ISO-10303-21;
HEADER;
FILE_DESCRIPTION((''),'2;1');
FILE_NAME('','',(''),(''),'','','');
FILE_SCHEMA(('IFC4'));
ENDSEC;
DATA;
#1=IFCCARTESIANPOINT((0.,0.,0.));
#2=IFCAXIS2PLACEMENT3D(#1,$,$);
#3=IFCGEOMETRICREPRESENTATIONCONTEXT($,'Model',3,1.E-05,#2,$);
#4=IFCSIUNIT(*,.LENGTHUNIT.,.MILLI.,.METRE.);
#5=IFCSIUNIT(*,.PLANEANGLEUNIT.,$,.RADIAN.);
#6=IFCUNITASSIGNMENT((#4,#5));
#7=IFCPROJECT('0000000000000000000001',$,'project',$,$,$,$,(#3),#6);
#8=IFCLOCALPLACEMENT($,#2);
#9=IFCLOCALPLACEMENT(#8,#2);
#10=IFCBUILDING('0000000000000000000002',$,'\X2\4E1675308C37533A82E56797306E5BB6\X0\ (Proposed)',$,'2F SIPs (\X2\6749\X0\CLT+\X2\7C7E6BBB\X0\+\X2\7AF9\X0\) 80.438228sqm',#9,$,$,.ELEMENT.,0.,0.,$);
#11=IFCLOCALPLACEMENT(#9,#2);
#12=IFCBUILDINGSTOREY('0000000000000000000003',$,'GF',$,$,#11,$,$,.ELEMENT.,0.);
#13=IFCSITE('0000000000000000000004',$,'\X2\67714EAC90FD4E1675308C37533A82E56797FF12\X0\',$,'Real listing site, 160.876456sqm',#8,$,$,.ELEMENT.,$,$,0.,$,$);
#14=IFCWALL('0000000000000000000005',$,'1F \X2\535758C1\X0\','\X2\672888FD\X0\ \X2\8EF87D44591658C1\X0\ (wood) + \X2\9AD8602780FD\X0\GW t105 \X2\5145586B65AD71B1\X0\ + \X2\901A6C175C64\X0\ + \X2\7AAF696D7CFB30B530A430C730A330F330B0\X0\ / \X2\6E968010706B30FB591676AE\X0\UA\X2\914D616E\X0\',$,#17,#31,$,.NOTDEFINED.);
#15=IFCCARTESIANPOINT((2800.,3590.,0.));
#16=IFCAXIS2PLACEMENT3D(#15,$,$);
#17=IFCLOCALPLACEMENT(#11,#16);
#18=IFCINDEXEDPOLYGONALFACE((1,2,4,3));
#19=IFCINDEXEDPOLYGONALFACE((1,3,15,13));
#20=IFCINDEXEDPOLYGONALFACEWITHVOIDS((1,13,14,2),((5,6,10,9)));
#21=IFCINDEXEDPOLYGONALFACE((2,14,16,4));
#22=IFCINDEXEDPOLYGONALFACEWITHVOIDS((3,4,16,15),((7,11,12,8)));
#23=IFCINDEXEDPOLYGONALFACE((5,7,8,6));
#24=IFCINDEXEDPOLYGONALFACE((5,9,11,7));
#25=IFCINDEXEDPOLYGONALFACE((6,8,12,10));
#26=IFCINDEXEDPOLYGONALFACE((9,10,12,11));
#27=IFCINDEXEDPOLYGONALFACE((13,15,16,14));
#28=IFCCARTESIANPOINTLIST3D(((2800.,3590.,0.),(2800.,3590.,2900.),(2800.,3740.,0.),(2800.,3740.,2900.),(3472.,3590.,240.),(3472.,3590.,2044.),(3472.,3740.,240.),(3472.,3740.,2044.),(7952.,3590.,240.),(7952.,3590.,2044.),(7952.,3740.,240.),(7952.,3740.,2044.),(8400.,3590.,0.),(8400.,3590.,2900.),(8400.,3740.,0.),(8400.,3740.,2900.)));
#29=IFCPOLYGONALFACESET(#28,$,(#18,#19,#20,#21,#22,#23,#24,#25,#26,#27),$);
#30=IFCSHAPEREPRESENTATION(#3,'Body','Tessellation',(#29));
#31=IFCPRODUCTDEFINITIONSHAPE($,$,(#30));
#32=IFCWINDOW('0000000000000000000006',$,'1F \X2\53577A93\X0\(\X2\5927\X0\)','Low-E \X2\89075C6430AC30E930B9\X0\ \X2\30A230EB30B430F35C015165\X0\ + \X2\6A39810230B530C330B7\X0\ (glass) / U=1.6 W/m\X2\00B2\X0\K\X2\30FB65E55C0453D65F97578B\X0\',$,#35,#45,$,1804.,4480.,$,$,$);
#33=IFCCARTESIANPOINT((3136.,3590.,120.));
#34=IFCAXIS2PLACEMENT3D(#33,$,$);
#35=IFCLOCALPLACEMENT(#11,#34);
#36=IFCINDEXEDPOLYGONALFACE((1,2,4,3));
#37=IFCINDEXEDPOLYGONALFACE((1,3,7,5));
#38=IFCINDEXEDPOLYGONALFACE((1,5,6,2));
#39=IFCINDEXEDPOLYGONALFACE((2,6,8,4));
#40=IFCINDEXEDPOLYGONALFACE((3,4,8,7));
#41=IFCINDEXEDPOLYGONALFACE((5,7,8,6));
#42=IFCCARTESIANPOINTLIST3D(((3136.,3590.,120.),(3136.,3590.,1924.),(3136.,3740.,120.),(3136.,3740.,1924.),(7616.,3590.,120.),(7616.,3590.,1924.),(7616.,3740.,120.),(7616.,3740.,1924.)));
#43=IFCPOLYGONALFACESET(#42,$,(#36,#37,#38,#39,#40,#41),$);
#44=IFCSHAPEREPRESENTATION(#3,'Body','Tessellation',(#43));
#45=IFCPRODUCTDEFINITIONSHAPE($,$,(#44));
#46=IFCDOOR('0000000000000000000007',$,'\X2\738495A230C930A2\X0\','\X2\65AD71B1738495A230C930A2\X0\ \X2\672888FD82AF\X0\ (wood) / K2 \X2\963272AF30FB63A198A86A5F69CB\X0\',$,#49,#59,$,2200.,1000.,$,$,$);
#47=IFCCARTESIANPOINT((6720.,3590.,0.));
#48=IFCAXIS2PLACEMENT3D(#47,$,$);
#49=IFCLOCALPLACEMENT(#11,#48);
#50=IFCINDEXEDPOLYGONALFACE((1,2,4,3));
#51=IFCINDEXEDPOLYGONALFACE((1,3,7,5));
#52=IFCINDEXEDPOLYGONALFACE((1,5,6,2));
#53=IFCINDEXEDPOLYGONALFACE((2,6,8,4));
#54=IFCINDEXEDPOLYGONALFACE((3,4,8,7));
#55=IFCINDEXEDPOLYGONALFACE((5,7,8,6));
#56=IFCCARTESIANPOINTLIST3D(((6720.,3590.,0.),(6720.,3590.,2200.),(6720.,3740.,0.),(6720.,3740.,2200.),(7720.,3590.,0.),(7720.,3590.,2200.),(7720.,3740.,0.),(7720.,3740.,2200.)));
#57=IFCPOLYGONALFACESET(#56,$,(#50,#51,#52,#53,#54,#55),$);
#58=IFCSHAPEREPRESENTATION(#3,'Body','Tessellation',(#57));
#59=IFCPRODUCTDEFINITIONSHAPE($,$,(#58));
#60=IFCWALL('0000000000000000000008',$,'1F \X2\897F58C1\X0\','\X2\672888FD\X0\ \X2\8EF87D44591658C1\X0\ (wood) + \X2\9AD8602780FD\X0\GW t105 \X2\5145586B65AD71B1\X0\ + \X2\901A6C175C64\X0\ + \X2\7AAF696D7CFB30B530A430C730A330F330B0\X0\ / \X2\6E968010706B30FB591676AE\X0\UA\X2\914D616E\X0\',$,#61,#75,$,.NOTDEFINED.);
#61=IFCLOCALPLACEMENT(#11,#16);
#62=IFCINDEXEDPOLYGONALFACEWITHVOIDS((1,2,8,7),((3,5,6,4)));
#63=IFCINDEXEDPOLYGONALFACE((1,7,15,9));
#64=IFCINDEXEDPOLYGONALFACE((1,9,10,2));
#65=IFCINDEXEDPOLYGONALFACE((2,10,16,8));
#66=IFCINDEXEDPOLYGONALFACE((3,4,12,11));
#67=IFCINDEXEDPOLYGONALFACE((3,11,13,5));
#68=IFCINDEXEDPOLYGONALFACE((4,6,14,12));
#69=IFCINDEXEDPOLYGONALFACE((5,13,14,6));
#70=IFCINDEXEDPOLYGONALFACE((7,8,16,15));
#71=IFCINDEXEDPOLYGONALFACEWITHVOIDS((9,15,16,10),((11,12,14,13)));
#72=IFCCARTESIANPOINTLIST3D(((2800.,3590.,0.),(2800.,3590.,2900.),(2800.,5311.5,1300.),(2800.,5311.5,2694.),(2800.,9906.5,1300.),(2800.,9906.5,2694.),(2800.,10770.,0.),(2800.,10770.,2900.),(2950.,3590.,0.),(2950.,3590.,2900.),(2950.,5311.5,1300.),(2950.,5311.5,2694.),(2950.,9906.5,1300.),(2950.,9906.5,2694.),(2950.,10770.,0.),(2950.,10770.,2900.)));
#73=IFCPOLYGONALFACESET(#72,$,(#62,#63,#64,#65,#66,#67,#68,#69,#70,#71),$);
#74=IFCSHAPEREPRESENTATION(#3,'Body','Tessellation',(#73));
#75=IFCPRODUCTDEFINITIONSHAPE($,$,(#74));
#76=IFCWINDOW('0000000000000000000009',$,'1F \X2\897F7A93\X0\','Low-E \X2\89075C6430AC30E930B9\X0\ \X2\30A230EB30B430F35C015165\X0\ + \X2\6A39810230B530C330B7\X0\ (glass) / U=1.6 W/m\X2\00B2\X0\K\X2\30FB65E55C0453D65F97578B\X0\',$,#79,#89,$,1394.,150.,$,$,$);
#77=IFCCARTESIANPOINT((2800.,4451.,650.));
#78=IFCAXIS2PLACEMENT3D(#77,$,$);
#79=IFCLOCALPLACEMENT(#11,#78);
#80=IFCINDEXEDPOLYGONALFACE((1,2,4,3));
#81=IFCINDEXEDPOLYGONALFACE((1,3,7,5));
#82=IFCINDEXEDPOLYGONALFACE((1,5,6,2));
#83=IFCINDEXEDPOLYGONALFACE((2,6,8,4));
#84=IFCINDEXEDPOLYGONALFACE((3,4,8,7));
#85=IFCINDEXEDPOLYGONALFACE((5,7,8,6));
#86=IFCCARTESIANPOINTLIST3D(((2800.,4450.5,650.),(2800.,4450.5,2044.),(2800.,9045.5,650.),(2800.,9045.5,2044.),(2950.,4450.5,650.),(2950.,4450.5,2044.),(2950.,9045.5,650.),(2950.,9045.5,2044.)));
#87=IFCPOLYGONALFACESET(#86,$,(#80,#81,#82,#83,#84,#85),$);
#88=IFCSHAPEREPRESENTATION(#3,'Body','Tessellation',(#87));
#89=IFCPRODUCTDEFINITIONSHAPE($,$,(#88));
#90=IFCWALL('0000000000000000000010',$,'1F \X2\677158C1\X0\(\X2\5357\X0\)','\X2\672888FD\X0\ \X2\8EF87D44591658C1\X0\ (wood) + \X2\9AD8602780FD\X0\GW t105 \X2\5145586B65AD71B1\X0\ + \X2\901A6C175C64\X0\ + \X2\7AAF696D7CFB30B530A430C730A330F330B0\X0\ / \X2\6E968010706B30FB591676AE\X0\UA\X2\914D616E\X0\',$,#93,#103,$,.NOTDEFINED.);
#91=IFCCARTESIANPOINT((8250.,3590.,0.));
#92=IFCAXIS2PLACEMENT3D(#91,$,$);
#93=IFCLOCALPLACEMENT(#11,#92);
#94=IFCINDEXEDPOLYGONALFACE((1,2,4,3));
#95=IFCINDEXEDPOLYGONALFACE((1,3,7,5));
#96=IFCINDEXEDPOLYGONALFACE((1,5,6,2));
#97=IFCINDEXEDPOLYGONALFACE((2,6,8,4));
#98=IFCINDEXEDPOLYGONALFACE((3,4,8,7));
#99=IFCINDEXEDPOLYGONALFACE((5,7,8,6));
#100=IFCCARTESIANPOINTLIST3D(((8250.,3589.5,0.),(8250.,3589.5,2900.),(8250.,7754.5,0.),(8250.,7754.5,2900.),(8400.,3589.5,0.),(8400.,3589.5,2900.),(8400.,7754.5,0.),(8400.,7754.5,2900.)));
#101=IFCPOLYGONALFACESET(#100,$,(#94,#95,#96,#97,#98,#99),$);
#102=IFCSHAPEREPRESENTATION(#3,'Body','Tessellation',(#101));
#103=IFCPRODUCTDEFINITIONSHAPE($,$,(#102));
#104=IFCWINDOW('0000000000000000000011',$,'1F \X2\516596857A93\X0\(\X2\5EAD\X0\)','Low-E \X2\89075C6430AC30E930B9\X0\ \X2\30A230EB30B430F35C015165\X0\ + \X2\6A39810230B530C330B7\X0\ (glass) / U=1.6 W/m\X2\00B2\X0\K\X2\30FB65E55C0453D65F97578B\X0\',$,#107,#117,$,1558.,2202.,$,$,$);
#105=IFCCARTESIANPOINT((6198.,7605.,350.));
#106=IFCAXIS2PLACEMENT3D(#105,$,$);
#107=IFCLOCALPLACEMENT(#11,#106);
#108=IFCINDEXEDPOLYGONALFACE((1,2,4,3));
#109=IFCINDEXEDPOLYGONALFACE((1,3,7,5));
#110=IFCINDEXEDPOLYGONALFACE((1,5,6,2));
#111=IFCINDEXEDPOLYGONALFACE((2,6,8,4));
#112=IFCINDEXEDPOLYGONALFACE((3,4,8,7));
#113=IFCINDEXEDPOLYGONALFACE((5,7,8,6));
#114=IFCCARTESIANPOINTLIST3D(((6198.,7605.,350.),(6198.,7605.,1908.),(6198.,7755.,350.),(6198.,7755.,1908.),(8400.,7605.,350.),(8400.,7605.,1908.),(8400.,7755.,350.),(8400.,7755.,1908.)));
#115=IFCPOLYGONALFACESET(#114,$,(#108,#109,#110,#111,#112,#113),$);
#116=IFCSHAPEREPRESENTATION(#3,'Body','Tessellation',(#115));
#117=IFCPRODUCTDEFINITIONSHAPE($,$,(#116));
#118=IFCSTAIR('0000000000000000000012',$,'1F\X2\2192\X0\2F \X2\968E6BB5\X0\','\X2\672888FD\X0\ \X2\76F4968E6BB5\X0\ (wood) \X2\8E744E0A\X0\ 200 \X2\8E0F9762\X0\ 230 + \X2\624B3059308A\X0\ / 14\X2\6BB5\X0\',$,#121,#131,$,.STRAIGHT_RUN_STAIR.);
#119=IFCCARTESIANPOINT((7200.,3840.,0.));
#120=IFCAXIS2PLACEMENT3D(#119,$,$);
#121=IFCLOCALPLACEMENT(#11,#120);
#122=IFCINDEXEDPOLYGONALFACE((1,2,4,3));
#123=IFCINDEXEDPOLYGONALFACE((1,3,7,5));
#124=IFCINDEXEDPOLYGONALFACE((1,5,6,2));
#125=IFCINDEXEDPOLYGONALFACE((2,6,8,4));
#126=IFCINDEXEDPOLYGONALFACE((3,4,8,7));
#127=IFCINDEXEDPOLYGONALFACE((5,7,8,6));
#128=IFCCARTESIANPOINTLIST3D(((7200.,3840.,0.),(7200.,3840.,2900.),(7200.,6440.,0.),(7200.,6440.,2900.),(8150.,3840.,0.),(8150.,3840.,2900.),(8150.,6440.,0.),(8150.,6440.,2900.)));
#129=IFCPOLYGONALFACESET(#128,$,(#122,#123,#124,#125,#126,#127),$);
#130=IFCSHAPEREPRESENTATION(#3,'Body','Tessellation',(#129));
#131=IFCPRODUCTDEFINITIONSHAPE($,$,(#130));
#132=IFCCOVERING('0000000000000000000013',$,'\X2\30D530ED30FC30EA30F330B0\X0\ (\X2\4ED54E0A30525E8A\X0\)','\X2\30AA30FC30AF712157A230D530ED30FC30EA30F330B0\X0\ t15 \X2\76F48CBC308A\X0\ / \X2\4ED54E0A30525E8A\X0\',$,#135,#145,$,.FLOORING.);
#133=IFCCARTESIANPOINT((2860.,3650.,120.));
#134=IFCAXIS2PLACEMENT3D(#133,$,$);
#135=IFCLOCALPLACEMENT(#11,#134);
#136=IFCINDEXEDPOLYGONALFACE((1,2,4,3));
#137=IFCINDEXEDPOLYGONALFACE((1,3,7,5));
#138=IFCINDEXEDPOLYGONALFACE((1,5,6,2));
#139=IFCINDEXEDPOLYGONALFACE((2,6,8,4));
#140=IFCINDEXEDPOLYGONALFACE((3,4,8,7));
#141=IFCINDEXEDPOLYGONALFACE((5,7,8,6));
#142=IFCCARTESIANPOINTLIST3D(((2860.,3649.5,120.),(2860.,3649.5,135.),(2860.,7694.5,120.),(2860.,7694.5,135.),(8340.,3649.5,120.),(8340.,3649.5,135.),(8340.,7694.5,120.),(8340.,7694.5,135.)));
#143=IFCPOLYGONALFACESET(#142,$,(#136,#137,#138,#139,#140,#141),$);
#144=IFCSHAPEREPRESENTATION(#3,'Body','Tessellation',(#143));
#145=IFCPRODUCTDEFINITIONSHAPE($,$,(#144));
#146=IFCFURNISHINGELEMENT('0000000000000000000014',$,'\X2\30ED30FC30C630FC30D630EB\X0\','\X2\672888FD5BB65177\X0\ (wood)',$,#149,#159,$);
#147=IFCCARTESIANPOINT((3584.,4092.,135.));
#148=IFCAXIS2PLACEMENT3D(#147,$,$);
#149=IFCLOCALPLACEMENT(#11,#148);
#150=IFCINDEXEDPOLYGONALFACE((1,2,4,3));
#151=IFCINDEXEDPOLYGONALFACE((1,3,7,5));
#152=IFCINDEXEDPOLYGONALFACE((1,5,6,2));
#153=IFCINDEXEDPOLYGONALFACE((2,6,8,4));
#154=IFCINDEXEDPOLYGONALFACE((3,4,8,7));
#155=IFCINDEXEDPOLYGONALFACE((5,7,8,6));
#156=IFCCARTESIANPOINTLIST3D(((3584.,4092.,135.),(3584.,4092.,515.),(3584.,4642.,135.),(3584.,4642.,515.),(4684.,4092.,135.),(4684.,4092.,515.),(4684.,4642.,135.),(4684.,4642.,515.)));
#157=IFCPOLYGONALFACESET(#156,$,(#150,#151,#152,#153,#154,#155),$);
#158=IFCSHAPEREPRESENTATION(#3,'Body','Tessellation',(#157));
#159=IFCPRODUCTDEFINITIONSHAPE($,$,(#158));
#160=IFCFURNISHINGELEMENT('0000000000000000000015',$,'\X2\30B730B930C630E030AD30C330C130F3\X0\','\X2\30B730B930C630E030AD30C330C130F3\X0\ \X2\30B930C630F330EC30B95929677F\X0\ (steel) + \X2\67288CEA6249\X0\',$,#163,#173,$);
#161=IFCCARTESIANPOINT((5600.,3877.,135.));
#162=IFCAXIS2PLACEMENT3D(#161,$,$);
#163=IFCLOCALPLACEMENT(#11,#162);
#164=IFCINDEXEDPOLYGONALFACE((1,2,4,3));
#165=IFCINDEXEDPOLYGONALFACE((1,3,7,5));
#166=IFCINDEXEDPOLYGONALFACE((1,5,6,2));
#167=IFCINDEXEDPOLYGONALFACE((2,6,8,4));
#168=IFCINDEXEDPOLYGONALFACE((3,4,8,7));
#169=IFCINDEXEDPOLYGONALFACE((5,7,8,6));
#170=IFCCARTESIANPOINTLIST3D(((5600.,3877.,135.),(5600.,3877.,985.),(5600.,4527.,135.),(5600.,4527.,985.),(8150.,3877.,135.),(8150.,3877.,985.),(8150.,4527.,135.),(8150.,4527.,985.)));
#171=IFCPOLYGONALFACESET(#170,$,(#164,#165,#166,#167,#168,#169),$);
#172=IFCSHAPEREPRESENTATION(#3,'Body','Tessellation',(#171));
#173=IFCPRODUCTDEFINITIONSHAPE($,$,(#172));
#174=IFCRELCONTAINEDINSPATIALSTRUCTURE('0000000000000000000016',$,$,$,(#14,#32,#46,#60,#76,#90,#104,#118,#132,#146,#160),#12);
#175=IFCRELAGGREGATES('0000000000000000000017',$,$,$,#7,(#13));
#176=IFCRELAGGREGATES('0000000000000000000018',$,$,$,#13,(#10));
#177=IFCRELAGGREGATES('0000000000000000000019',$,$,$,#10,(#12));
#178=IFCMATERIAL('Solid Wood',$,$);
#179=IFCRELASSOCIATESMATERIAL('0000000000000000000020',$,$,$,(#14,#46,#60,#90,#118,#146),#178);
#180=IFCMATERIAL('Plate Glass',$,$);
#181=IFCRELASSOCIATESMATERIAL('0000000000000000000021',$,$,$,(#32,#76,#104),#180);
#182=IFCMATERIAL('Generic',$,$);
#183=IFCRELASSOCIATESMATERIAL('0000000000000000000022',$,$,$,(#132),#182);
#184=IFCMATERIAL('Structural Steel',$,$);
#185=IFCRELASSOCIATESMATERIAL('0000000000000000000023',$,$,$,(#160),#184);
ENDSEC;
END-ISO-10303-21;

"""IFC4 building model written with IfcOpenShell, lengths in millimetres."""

from ifc_helpers import new_model, si_unit, frame, frame_2d, origin, place, context, project, spatial, rectangle, extrude, material, element, fill, save


model = new_model("IFC4")

# Units and contexts
model_context = context("Model", 3, precision=1e-05, world=origin())
ifc_project = project(units=[si_unit("LENGTHUNIT", "METRE", prefix="MILLI"), si_unit("PLANEANGLEUNIT", "RADIAN")], contexts=[model_context])

# Site, building, storey
site_placement = place(None, origin())
site = spatial("IfcSite", under=ifc_project, at=site_placement, Name="東京都世田谷区若林２", ObjectType="Real listing site, 160.876456sqm", CompositionType="ELEMENT", RefElevation=0.0)
building_placement = place(site_placement, origin())
building = spatial("IfcBuilding", under=site, at=building_placement, Name="世田谷区若林の家 (Proposed)", ObjectType="2F SIPs (杉CLT+籾殻+竹) 80.438228sqm", CompositionType="ELEMENT", ElevationOfRefHeight=0.0, ElevationOfTerrain=0.0)
storey_placement = place(building_placement, origin())
storey = spatial("IfcBuildingStorey", under=building, at=storey_placement, Name="GF", CompositionType="ELEMENT", Elevation=0.0)

# Shared definitions
ifc_material_1 = material(Name="Solid Wood")

# Wall, openings, window, door
wall_1_placement = place(storey_placement, frame((2800.0, 3590.0, 0.0)))
wall_1 = element("IfcWall", 1, at=wall_1_placement, inside=storey, material=ifc_material_1, Name="1F 南壁", Description="木製 軸組外壁 (wood) + 高性能GW t105 充填断熱 + 通気層 + 窯業系サイディング / 準耐火・外皮UA配慮", PredefinedType="NOTDEFINED", context=model_context, shape_type="SweptSolid", body=[
    extrude(rectangle(XDim=5600.0, YDim=150.0, at=frame_2d((2800.0, 75.0))), frame((2800.0, 3590.0, 0.0)), (0.0, 0.0, 1.0), 2900.0),
])
opening_1_placement = place(storey_placement, frame((3136.0, 3590.0, 120.0)))
opening_1 = element("IfcOpeningElement", 2, at=opening_1_placement, cuts=wall_1, PredefinedType="NOTDEFINED", context=model_context, shape_type="SweptSolid", body=[
    extrude(rectangle(XDim=4480.0, YDim=150.0, at=frame_2d((2240.0, 75.0))), frame((3136.0, 3590.0, 120.0)), (0.0, 0.0, 1.0), 1804.0),
])
opening_2_placement = place(storey_placement, frame((6720.0, 3590.0, 0.0)))
opening_2 = element("IfcOpeningElement", 3, at=opening_2_placement, cuts=wall_1, PredefinedType="NOTDEFINED", context=model_context, shape_type="SweptSolid", body=[
    extrude(rectangle(XDim=1000.0, YDim=150.0, at=frame_2d((500.0, 75.0))), frame((6720.0, 3590.0, 0.0)), (0.0, 0.0, 1.0), 2200.0),
])
ifc_material_2 = material(Name="Plate Glass")
window_1_placement = place(storey_placement, frame((3136.0, 3590.0, 120.0)))
window_1 = element("IfcWindow", 4, at=window_1_placement, inside=storey, material=ifc_material_2, Name="1F 南窓(大)", Description="Low-E 複層ガラス アルゴン封入 + 樹脂サッシ (glass) / U=1.6 W/m²K・日射取得型", OverallHeight=1804.0, OverallWidth=4480.0, context=model_context, shape_type="SweptSolid", body=[
    extrude(rectangle(XDim=4480.0, YDim=150.0, at=frame_2d((2240.0, 75.0))), frame((3136.0, 3590.0, 120.0)), (0.0, 0.0, 1.0), 1804.0),
])
fill(opening_1, window_1)
door_1_placement = place(storey_placement, frame((6720.0, 3590.0, 0.0)))
door_1 = element("IfcDoor", 5, at=door_1_placement, inside=storey, material=ifc_material_1, Name="玄関ドア", Description="断熱玄関ドア 木製芯 (wood) / K2 防犯・採風機構", OverallHeight=2200.0, OverallWidth=1000.0, context=model_context, shape_type="SweptSolid", body=[
    extrude(rectangle(XDim=1000.0, YDim=150.0, at=frame_2d((500.0, 75.0))), frame((6720.0, 3590.0, 0.0)), (0.0, 0.0, 1.0), 2200.0),
])
fill(opening_2, door_1)

# Walls, openings, windows
wall_2_placement = place(storey_placement, frame((2800.0, 3590.0, 0.0)))
wall_2 = element("IfcWall", 6, at=wall_2_placement, inside=storey, material=ifc_material_1, Name="1F 西壁", Description="木製 軸組外壁 (wood) + 高性能GW t105 充填断熱 + 通気層 + 窯業系サイディング / 準耐火・外皮UA配慮", PredefinedType="NOTDEFINED", context=model_context, shape_type="SweptSolid", body=[
    extrude(rectangle(XDim=150.0, YDim=7180.0, at=frame_2d((75.0, 3590.0))), frame((2800.0, 3590.0, 0.0)), (0.0, 0.0, 1.0), 2900.0),
])
opening_3_placement = place(storey_placement, frame((2800.0, 4451.0, 650.0)))
opening_3 = element("IfcOpeningElement", 7, at=opening_3_placement, cuts=wall_2, PredefinedType="NOTDEFINED", context=model_context, shape_type="SweptSolid", body=[
    extrude(rectangle(XDim=150.0, YDim=4595.0, at=frame_2d((75.0, 2297.0))), frame((2800.0, 4451.0, 650.0)), (0.0, 0.0, 1.0), 1394.0),
])
window_2_placement = place(storey_placement, frame((2800.0, 4451.0, 650.0)))
window_2 = element("IfcWindow", 8, at=window_2_placement, inside=storey, material=ifc_material_2, Name="1F 西窓", Description="Low-E 複層ガラス アルゴン封入 + 樹脂サッシ (glass) / U=1.6 W/m²K・日射取得型", OverallHeight=1394.0, OverallWidth=150.0, context=model_context, shape_type="SweptSolid", body=[
    extrude(rectangle(XDim=150.0, YDim=4595.0, at=frame_2d((75.0, 2297.0))), frame((2800.0, 4451.0, 650.0)), (0.0, 0.0, 1.0), 1394.0),
])
fill(opening_3, window_2)
wall_3_placement = place(storey_placement, frame((8250.0, 3590.0, 0.0)))
wall_3 = element("IfcWall", 9, at=wall_3_placement, inside=storey, material=ifc_material_1, Name="1F 東壁(南)", Description="木製 軸組外壁 (wood) + 高性能GW t105 充填断熱 + 通気層 + 窯業系サイディング / 準耐火・外皮UA配慮", PredefinedType="NOTDEFINED", context=model_context, shape_type="SweptSolid", body=[
    extrude(rectangle(XDim=150.0, YDim=4165.0, at=frame_2d((75.0, 2082.0))), frame((8250.0, 3590.0, 0.0)), (0.0, 0.0, 1.0), 2900.0),
])
opening_4_placement = place(storey_placement, frame((6198.0, 7605.0, 350.0)))
opening_4 = element("IfcOpeningElement", 10, at=opening_4_placement, cuts=wall_3, PredefinedType="NOTDEFINED", context=model_context, shape_type="SweptSolid", body=[
    extrude(rectangle(XDim=2202.0, YDim=150.0, at=frame_2d((1101.0, 75.0))), frame((6198.0, 7605.0, 350.0)), (0.0, 0.0, 1.0), 1558.0),
])
window_3_placement = place(storey_placement, frame((6198.0, 7605.0, 350.0)))
window_3 = element("IfcWindow", 11, at=window_3_placement, inside=storey, material=ifc_material_2, Name="1F 入隅窓(庭)", Description="Low-E 複層ガラス アルゴン封入 + 樹脂サッシ (glass) / U=1.6 W/m²K・日射取得型", OverallHeight=1558.0, OverallWidth=2202.0, context=model_context, shape_type="SweptSolid", body=[
    extrude(rectangle(XDim=2202.0, YDim=150.0, at=frame_2d((1101.0, 75.0))), frame((6198.0, 7605.0, 350.0)), (0.0, 0.0, 1.0), 1558.0),
])
fill(opening_4, window_3)

# Stair
stair_placement = place(storey_placement, frame((7200.0, 3840.0, 0.0)))
element("IfcStair", 12, at=stair_placement, inside=storey, material=ifc_material_1, Name="1F→2F 階段", Description="木製 直階段 (wood) 蹴上 200 踏面 230 + 手すり / 14段", PredefinedType="STRAIGHT_RUN_STAIR", context=model_context, shape_type="SweptSolid", body=[
    extrude(rectangle(XDim=950.0, YDim=2600.0, at=frame_2d((475.0, 1300.0))), frame((7200.0, 3840.0, 0.0)), (0.0, 0.0, 1.0), 2900.0),
])

# Covering
ifc_material_3 = material(Name="Generic")
covering_placement = place(storey_placement, frame((2860.0, 3650.0, 120.0)))
element("IfcCovering", 13, at=covering_placement, inside=storey, material=ifc_material_3, Name="フローリング (仕上げ床)", Description="オーク無垢フローリング t15 直貼り / 仕上げ床", PredefinedType="FLOORING", context=model_context, shape_type="SweptSolid", body=[
    extrude(rectangle(XDim=5480.0, YDim=4045.0, at=frame_2d((2740.0, 2022.0))), frame((2860.0, 3650.0, 120.0)), (0.0, 0.0, 1.0), 15.0),
])

# Furnishing elements
furnishing_1_placement = place(storey_placement, frame((3584.0, 4092.0, 135.0)))
element("IfcFurnishingElement", 14, at=furnishing_1_placement, inside=storey, material=ifc_material_1, Name="ローテーブル", Description="木製家具 (wood)", context=model_context, shape_type="SweptSolid", body=[
    extrude(rectangle(XDim=1100.0, YDim=550.0, at=frame_2d((550.0, 275.0))), frame((3584.0, 4092.0, 135.0)), (0.0, 0.0, 1.0), 380.0),
])
ifc_material_4 = material(Name="Structural Steel")
furnishing_2_placement = place(storey_placement, frame((5600.0, 3877.0, 135.0)))
element("IfcFurnishingElement", 15, at=furnishing_2_placement, inside=storey, material=ifc_material_4, Name="システムキッチン", Description="システムキッチン ステンレス天板 (steel) + 木質扉", context=model_context, shape_type="SweptSolid", body=[
    extrude(rectangle(XDim=2550.0, YDim=650.0, at=frame_2d((1275.0, 325.0))), frame((5600.0, 3877.0, 135.0)), (0.0, 0.0, 1.0), 850.0),
])

save(model, "model.ifc")
